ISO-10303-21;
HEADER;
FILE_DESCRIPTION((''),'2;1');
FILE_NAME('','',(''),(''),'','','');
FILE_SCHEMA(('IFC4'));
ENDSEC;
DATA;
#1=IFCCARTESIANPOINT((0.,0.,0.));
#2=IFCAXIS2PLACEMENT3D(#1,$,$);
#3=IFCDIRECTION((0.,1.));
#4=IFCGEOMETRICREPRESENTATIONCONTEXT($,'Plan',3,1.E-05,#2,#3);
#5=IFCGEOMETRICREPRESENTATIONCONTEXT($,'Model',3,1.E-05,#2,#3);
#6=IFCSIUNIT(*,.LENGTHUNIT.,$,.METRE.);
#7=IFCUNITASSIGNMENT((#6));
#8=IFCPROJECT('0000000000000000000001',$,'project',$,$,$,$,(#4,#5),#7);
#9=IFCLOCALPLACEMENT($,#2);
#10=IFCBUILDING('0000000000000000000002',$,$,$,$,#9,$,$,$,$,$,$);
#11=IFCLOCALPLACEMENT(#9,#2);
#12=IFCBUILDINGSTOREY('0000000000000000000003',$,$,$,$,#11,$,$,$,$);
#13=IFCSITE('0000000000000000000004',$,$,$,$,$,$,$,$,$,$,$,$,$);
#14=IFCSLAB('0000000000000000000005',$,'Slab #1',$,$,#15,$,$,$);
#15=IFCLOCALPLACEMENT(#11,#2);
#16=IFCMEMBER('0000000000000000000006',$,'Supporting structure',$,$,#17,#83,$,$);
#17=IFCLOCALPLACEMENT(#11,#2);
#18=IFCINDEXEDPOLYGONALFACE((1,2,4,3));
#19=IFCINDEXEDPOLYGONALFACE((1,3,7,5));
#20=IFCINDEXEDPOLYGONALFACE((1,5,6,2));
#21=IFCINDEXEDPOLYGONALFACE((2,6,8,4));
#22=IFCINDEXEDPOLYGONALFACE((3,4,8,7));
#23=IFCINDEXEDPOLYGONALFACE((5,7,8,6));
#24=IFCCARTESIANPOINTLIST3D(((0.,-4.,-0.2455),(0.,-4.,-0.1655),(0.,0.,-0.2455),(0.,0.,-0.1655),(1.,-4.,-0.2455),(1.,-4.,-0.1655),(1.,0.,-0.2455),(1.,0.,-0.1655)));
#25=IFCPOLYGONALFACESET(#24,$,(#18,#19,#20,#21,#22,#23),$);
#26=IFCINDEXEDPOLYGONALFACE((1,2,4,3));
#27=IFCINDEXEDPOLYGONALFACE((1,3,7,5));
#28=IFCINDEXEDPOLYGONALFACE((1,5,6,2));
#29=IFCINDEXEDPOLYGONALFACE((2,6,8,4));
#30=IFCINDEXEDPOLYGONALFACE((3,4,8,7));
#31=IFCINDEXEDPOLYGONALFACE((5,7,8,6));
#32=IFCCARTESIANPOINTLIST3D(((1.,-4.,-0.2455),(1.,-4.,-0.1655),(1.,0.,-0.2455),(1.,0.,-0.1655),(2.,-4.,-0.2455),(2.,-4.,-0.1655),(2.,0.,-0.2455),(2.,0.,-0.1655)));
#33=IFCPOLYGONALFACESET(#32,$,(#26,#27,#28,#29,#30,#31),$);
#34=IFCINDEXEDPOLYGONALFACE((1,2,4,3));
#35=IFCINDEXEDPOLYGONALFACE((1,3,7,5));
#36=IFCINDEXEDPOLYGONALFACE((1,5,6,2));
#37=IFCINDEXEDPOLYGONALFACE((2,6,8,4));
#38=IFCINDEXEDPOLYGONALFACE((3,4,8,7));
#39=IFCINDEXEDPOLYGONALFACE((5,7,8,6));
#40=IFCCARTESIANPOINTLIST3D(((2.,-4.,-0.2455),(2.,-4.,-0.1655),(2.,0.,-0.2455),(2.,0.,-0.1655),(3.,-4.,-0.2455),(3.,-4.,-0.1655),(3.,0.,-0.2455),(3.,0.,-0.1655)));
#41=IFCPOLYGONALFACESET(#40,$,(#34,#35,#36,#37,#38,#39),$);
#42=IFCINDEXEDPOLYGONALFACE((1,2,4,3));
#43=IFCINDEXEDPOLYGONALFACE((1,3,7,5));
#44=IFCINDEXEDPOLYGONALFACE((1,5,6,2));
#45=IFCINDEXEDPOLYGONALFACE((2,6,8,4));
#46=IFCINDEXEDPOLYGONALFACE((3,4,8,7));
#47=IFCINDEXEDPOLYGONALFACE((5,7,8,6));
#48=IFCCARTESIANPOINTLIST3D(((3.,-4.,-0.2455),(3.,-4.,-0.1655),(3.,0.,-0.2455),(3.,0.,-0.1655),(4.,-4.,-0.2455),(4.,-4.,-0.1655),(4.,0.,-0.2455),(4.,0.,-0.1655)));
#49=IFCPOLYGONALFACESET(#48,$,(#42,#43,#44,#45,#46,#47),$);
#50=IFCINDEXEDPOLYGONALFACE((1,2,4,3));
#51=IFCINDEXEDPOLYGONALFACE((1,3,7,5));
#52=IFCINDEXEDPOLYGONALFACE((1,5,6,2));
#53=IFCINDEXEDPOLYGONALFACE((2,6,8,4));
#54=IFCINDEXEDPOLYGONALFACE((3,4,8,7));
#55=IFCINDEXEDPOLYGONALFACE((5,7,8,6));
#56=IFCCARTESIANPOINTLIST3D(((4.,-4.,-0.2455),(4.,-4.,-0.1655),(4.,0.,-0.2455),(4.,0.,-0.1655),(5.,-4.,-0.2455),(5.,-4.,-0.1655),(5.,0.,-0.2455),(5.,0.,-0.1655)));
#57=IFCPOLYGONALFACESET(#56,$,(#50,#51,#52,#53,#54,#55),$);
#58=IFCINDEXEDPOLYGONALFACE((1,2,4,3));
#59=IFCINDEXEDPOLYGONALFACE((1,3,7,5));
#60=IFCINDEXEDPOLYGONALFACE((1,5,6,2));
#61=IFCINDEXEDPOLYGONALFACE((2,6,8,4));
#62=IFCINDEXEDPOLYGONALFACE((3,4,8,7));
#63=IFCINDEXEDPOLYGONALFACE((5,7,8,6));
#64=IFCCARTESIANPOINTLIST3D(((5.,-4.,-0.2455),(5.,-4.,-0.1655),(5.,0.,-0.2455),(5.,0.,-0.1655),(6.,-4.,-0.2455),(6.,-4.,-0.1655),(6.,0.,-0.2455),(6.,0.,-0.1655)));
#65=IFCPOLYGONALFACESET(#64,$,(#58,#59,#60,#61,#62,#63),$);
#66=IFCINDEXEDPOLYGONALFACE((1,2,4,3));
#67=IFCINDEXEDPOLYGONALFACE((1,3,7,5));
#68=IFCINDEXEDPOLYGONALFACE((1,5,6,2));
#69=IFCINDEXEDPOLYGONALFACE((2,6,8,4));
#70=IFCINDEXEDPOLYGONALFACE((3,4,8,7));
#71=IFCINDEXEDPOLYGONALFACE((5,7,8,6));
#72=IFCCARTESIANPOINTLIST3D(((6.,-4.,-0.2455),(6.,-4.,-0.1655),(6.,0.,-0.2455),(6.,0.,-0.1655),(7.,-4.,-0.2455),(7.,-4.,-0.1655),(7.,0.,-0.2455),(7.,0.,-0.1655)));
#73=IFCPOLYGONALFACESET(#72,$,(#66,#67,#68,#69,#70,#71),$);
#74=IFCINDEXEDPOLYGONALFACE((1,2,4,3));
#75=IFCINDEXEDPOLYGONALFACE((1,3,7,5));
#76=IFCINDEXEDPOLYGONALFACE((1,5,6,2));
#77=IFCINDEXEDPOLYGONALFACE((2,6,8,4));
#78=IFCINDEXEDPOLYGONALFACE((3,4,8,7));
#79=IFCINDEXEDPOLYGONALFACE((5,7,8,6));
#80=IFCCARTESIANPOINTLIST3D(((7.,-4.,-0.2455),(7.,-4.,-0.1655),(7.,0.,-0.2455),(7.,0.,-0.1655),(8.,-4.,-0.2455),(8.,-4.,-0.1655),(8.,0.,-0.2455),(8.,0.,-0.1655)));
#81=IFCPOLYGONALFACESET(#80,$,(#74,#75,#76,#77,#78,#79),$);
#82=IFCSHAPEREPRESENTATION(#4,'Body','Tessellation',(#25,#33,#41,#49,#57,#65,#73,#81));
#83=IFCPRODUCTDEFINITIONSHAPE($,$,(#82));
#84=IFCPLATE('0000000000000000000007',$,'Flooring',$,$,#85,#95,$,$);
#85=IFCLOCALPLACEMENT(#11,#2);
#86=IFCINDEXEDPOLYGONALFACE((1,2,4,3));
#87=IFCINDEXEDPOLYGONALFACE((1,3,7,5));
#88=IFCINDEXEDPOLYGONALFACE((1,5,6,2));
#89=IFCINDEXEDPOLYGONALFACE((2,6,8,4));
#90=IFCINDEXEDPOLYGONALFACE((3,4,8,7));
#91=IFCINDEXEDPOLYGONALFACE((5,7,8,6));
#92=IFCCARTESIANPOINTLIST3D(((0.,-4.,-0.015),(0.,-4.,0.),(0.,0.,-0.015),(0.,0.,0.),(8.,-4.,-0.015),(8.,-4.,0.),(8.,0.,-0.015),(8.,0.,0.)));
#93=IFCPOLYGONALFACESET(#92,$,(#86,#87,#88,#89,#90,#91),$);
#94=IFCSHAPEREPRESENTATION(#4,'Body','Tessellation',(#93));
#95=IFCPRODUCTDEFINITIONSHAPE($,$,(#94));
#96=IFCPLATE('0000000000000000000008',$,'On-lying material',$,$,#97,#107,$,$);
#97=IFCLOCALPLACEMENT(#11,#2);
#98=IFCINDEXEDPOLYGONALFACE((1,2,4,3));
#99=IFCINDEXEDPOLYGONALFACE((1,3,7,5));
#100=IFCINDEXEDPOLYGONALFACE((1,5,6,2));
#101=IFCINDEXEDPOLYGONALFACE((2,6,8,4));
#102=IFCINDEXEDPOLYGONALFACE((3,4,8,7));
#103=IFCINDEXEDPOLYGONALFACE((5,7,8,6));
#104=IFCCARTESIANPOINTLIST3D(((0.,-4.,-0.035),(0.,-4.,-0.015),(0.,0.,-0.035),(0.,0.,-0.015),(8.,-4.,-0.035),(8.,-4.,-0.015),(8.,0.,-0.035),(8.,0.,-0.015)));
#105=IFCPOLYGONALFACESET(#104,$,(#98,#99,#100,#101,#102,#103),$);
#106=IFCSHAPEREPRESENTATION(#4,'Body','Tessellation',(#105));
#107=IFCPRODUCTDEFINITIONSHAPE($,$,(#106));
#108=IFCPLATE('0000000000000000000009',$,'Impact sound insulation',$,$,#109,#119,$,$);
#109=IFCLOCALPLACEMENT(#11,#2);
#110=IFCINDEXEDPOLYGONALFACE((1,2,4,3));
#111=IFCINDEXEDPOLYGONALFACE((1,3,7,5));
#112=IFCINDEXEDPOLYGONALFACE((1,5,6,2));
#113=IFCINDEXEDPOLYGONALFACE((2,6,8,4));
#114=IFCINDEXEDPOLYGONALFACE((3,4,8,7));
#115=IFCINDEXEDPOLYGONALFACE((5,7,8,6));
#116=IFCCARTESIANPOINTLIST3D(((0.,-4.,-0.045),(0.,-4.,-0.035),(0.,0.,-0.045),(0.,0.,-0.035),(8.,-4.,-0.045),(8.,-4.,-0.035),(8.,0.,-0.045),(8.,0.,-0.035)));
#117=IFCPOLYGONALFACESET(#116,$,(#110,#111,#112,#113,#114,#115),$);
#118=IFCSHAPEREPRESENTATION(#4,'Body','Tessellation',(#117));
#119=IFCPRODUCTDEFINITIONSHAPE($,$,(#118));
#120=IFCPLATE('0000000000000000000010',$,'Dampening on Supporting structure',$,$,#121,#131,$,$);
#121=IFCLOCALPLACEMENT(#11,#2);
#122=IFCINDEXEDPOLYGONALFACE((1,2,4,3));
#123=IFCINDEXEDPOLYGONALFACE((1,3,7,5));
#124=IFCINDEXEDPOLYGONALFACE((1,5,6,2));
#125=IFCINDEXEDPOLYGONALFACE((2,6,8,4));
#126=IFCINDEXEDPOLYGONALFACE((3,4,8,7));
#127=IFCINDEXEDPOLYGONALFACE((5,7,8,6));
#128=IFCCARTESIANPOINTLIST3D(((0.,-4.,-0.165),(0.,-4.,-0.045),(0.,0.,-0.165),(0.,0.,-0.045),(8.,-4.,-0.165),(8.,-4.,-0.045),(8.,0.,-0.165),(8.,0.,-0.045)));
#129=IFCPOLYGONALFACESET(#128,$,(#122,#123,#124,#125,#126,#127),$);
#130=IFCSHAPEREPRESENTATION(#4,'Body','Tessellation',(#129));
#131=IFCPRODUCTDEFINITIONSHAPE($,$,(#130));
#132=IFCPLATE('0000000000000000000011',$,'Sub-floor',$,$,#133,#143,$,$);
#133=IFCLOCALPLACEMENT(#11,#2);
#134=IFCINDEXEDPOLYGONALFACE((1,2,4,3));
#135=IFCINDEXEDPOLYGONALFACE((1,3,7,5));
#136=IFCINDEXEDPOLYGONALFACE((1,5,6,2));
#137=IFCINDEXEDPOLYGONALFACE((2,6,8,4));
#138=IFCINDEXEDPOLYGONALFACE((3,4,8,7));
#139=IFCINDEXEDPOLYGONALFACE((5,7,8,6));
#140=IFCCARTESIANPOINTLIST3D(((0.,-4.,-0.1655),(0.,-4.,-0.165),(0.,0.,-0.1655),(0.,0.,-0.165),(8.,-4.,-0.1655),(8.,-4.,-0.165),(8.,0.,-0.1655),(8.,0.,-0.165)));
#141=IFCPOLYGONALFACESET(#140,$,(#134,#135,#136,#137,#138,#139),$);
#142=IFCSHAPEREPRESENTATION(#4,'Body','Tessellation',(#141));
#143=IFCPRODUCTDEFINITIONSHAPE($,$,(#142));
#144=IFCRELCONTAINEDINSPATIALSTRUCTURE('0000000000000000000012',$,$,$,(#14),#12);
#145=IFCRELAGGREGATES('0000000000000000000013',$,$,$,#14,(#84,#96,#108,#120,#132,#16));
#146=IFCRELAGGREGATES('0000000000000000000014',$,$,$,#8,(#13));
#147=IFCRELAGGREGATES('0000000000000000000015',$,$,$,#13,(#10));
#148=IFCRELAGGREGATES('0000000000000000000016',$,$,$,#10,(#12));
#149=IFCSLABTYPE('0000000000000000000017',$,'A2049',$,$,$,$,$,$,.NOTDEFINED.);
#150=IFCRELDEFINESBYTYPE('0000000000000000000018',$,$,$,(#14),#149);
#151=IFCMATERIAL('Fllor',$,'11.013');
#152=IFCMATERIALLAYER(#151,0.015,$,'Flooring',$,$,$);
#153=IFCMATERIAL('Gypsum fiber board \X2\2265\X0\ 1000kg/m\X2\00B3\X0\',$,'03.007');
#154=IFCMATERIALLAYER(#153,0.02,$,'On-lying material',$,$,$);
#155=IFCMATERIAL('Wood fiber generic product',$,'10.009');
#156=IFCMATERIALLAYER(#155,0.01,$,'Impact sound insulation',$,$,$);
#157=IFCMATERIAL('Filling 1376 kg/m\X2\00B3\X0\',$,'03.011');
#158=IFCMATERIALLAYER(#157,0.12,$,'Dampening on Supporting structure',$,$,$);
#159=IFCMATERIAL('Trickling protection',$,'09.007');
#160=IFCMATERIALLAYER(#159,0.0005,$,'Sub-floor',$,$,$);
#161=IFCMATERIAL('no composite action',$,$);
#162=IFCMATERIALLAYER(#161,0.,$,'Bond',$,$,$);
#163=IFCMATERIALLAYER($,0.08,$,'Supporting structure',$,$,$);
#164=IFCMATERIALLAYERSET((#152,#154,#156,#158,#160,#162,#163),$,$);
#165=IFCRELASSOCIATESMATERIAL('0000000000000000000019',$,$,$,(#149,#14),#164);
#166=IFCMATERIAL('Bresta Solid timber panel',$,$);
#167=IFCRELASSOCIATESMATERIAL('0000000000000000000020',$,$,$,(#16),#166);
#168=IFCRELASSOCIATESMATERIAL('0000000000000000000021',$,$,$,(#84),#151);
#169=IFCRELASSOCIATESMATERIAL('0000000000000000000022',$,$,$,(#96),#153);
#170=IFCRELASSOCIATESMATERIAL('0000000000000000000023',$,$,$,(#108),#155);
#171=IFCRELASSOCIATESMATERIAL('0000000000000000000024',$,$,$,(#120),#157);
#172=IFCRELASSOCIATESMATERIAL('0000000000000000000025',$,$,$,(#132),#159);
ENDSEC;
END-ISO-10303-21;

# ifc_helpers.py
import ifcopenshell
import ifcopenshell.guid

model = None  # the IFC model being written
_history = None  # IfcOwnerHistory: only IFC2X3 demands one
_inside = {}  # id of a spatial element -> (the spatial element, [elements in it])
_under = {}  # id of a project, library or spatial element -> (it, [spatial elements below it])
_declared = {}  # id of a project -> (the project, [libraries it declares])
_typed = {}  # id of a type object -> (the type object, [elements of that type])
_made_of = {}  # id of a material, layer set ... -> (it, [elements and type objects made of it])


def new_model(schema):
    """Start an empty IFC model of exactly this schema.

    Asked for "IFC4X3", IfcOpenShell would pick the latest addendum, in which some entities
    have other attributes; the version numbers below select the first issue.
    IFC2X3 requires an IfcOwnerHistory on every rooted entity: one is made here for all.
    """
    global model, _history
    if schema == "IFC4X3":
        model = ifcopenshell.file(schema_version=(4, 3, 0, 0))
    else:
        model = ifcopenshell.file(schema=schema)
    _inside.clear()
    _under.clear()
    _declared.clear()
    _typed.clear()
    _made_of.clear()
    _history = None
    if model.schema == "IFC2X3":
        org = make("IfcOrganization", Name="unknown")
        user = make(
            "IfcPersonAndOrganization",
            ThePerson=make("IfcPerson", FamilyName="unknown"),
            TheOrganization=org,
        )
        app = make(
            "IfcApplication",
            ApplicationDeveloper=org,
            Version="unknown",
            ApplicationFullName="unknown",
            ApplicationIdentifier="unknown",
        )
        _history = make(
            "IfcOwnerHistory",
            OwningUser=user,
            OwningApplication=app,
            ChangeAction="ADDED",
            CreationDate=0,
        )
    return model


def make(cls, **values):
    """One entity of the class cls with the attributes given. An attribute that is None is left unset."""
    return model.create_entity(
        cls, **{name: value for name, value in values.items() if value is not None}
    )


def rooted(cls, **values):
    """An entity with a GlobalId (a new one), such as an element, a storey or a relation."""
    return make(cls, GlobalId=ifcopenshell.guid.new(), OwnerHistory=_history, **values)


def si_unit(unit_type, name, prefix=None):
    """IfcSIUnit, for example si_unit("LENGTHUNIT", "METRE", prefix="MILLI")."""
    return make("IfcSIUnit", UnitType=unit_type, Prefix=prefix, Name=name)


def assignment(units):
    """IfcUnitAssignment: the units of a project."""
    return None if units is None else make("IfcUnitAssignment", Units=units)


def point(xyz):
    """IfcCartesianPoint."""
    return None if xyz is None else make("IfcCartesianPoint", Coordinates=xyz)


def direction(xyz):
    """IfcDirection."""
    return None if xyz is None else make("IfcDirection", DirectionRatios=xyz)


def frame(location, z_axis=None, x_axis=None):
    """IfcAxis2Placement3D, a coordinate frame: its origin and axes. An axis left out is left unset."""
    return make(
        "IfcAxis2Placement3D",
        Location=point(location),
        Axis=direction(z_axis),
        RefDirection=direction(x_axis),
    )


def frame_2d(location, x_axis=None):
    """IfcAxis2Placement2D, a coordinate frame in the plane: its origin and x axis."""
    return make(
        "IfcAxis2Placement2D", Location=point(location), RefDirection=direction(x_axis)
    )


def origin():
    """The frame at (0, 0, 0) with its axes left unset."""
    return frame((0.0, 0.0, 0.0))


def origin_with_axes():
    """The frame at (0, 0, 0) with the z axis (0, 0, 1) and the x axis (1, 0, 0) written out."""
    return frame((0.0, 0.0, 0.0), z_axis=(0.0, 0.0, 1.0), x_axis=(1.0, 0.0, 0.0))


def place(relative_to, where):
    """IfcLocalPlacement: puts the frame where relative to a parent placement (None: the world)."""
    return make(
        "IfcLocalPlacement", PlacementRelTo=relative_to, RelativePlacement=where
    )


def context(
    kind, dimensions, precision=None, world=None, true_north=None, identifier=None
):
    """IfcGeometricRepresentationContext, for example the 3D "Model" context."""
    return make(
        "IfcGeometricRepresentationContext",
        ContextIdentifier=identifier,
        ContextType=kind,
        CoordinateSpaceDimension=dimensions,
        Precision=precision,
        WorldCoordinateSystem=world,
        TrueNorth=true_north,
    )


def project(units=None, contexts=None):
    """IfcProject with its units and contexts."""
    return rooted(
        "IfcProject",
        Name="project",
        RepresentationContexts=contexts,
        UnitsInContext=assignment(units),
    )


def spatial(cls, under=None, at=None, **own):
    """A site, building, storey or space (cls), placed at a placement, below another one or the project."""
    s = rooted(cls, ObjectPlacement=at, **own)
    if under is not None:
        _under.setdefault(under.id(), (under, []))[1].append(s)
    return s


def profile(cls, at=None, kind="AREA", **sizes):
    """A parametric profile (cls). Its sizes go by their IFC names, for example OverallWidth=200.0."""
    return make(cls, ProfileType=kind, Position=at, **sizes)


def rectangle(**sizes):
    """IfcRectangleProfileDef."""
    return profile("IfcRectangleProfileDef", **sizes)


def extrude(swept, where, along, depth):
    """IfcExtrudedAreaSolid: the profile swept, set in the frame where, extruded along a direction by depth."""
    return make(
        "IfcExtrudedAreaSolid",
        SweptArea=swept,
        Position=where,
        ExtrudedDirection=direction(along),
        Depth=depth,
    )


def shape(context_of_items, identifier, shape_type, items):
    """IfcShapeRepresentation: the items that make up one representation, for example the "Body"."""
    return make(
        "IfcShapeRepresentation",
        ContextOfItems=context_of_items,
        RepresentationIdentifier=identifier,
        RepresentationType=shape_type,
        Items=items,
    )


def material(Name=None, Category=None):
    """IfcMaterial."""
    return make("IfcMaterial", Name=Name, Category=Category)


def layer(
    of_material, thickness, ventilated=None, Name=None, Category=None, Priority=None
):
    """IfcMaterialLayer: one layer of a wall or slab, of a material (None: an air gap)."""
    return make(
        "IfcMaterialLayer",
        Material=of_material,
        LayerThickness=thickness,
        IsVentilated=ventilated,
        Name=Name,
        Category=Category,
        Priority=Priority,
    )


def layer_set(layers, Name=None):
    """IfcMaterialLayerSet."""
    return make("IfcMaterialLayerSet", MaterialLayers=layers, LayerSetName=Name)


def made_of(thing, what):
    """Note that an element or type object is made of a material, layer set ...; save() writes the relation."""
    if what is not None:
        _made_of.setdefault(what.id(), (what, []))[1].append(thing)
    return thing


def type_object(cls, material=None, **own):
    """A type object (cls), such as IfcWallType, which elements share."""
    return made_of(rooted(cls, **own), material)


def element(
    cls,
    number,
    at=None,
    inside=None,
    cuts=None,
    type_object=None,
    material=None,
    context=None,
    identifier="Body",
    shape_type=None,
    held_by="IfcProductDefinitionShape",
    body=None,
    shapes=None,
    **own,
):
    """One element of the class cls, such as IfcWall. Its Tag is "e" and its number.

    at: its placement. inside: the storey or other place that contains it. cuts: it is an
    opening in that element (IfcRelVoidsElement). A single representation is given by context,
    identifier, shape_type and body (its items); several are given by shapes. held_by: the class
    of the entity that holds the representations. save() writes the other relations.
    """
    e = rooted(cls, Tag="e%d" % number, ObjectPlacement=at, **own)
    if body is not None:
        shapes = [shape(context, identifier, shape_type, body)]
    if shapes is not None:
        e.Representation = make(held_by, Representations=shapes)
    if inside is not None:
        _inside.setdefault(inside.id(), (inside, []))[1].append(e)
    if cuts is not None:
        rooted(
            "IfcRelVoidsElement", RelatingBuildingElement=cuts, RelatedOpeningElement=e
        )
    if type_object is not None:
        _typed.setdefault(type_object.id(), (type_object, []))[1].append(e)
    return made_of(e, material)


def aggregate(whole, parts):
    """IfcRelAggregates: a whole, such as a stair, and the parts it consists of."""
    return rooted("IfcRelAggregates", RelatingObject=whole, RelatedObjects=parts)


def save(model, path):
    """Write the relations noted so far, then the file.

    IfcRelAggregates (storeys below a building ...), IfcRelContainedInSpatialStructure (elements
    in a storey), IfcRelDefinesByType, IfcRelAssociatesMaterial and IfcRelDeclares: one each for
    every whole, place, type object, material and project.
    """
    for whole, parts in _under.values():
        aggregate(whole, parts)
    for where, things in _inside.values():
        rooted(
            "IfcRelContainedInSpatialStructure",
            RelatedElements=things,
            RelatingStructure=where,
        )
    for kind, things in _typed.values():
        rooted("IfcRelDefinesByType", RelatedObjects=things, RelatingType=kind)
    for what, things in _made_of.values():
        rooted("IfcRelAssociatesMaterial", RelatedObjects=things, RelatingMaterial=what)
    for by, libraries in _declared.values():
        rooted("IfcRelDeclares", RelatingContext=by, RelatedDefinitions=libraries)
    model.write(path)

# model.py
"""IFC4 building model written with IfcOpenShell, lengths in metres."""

from ifc_helpers import new_model, si_unit, direction, frame, frame_2d, origin, origin_with_axes, place, context, project, spatial, rectangle, extrude, material, layer, layer_set, type_object, element, aggregate, save


model = new_model("IFC4")

# Units and contexts
plan_context = context("Plan", 3, precision=1e-05, world=origin(), true_north=direction((0.0, 1.0)))
model_context = context("Model", 3, precision=1e-05, world=origin(), true_north=direction((0.0, 1.0)))
ifc_project = project(units=[si_unit("LENGTHUNIT", "METRE")], contexts=[plan_context, model_context])

# Site, building, storey
site = spatial("IfcSite", under=ifc_project)
building_placement = place(None, origin())
building = spatial("IfcBuilding", under=site, at=building_placement)
storey_placement = place(building_placement, origin())
storey = spatial("IfcBuildingStorey", under=building, at=storey_placement)

# Slab, member, plates
ifc_material_1 = material(Name="Fllor", Category="11.013")
ifc_layer_1 = layer(ifc_material_1, 0.015, Name="Flooring")
ifc_material_2 = material(Name="Gypsum fiber board ≥ 1000kg/m³", Category="03.007")
ifc_layer_2 = layer(ifc_material_2, 0.02, Name="On-lying material")
ifc_material_3 = material(Name="Wood fiber generic product", Category="10.009")
ifc_layer_3 = layer(ifc_material_3, 0.01, Name="Impact sound insulation")
ifc_material_4 = material(Name="Filling 1376 kg/m³", Category="03.011")
ifc_layer_4 = layer(ifc_material_4, 0.12, Name="Dampening on Supporting structure")
ifc_material_5 = material(Name="Trickling protection", Category="09.007")
ifc_layer_5 = layer(ifc_material_5, 0.0005, Name="Sub-floor")
ifc_material_6 = material(Name="no composite action")
ifc_layer_6 = layer(ifc_material_6, 0.0, Name="Bond")
ifc_layer_7 = layer(None, 0.08, Name="Supporting structure")
ifc_layer_set = layer_set([ifc_layer_1, ifc_layer_2, ifc_layer_3, ifc_layer_4, ifc_layer_5, ifc_layer_6, ifc_layer_7])
slab_type = type_object("IfcSlabType", Name="A2049", PredefinedType="NOTDEFINED", material=ifc_layer_set)
slab_placement = place(None, frame((0.0, 0.0, 0.0), z_axis=(0.0, 0.0, -1.0), x_axis=(1.0, 0.0, 0.0)))
slab = element("IfcSlab", 1, at=slab_placement, inside=storey, type_object=slab_type, material=ifc_layer_set, Name="Slab #1")
ifc_material_7 = material(Name="Bresta Solid timber panel")
member_placement = place(slab_placement, origin())
member = element("IfcMember", 2, at=member_placement, material=ifc_material_7, Name="Supporting structure", context=plan_context, shape_type="SweptSolid", body=[
    extrude(rectangle(XDim=1.0, YDim=0.08, at=frame_2d((0.5, 0.04), x_axis=(1.0, 0.0))), frame((0.0, 4.0, 0.1655), z_axis=(0.0, -1.0, 0.0), x_axis=(1.0, 0.0, 0.0)), (0.0, 0.0, 1.0), 4.0),
    extrude(rectangle(XDim=1.0, YDim=0.08, at=frame_2d((0.5, 0.04), x_axis=(1.0, 0.0))), frame((1.0, 4.0, 0.1655), z_axis=(0.0, -1.0, 0.0), x_axis=(1.0, 0.0, 0.0)), (0.0, 0.0, 1.0), 4.0),
    extrude(rectangle(XDim=1.0, YDim=0.08, at=frame_2d((0.5, 0.04), x_axis=(1.0, 0.0))), frame((2.0, 4.0, 0.1655), z_axis=(0.0, -1.0, 0.0), x_axis=(1.0, 0.0, 0.0)), (0.0, 0.0, 1.0), 4.0),
    extrude(rectangle(XDim=1.0, YDim=0.08, at=frame_2d((0.5, 0.04), x_axis=(1.0, 0.0))), frame((3.0, 4.0, 0.1655), z_axis=(0.0, -1.0, 0.0), x_axis=(1.0, 0.0, 0.0)), (0.0, 0.0, 1.0), 4.0),
    extrude(rectangle(XDim=1.0, YDim=0.08, at=frame_2d((0.5, 0.04), x_axis=(1.0, 0.0))), frame((4.0, 4.0, 0.1655), z_axis=(0.0, -1.0, 0.0), x_axis=(1.0, 0.0, 0.0)), (0.0, 0.0, 1.0), 4.0),
    extrude(rectangle(XDim=1.0, YDim=0.08, at=frame_2d((0.5, 0.04), x_axis=(1.0, 0.0))), frame((5.0, 4.0, 0.1655), z_axis=(0.0, -1.0, 0.0), x_axis=(1.0, 0.0, 0.0)), (0.0, 0.0, 1.0), 4.0),
    extrude(rectangle(XDim=1.0, YDim=0.08, at=frame_2d((0.5, 0.04), x_axis=(1.0, 0.0))), frame((6.0, 4.0, 0.1655), z_axis=(0.0, -1.0, 0.0), x_axis=(1.0, 0.0, 0.0)), (0.0, 0.0, 1.0), 4.0),
    extrude(rectangle(XDim=1.0, YDim=0.08, at=frame_2d((0.5, 0.04), x_axis=(1.0, 0.0))), frame((7.0, 4.0, 0.1655), z_axis=(0.0, -1.0, 0.0), x_axis=(1.0, 0.0, 0.0)), (0.0, 0.0, 1.0), 4.0),
])
plate_1_placement = place(slab_placement, origin())
plate_1 = element("IfcPlate", 3, at=plate_1_placement, material=ifc_material_1, Name="Flooring", context=plan_context, shape_type="SweptSolid", body=[
    extrude(rectangle(XDim=8.0, YDim=4.0, at=frame_2d((4.0, 2.0), x_axis=(1.0, 0.0))), origin_with_axes(), (0.0, 0.0, 1.0), 0.015),
])
plate_2_placement = place(slab_placement, origin())
plate_2 = element("IfcPlate", 4, at=plate_2_placement, material=ifc_material_2, Name="On-lying material", context=plan_context, shape_type="SweptSolid", body=[
    extrude(rectangle(XDim=8.0, YDim=4.0, at=frame_2d((4.0, 2.0), x_axis=(1.0, 0.0))), frame((0.0, 0.0, 0.015), z_axis=(0.0, 0.0, 1.0), x_axis=(1.0, 0.0, 0.0)), (0.0, 0.0, 1.0), 0.02),
])
plate_3_placement = place(slab_placement, origin())
plate_3 = element("IfcPlate", 5, at=plate_3_placement, material=ifc_material_3, Name="Impact sound insulation", context=plan_context, shape_type="SweptSolid", body=[
    extrude(rectangle(XDim=8.0, YDim=4.0, at=frame_2d((4.0, 2.0), x_axis=(1.0, 0.0))), frame((0.0, 0.0, 0.035), z_axis=(0.0, 0.0, 1.0), x_axis=(1.0, 0.0, 0.0)), (0.0, 0.0, 1.0), 0.01),
])
plate_4_placement = place(slab_placement, origin())
plate_4 = element("IfcPlate", 6, at=plate_4_placement, material=ifc_material_4, Name="Dampening on Supporting structure", context=plan_context, shape_type="SweptSolid", body=[
    extrude(rectangle(XDim=8.0, YDim=4.0, at=frame_2d((4.0, 2.0), x_axis=(1.0, 0.0))), frame((0.0, 0.0, 0.045), z_axis=(0.0, 0.0, 1.0), x_axis=(1.0, 0.0, 0.0)), (0.0, 0.0, 1.0), 0.12),
])
plate_5_placement = place(slab_placement, origin())
plate_5 = element("IfcPlate", 7, at=plate_5_placement, material=ifc_material_5, Name="Sub-floor", context=plan_context, shape_type="SweptSolid", body=[
    extrude(rectangle(XDim=8.0, YDim=4.0, at=frame_2d((4.0, 2.0), x_axis=(1.0, 0.0))), frame((0.0, 0.0, 0.165), z_axis=(0.0, 0.0, 1.0), x_axis=(1.0, 0.0, 0.0)), (0.0, 0.0, 1.0), 0.0005),
])
aggregate(slab, [plate_1, plate_2, plate_3, plate_4, plate_5, member])

save(model, "model.ifc")
